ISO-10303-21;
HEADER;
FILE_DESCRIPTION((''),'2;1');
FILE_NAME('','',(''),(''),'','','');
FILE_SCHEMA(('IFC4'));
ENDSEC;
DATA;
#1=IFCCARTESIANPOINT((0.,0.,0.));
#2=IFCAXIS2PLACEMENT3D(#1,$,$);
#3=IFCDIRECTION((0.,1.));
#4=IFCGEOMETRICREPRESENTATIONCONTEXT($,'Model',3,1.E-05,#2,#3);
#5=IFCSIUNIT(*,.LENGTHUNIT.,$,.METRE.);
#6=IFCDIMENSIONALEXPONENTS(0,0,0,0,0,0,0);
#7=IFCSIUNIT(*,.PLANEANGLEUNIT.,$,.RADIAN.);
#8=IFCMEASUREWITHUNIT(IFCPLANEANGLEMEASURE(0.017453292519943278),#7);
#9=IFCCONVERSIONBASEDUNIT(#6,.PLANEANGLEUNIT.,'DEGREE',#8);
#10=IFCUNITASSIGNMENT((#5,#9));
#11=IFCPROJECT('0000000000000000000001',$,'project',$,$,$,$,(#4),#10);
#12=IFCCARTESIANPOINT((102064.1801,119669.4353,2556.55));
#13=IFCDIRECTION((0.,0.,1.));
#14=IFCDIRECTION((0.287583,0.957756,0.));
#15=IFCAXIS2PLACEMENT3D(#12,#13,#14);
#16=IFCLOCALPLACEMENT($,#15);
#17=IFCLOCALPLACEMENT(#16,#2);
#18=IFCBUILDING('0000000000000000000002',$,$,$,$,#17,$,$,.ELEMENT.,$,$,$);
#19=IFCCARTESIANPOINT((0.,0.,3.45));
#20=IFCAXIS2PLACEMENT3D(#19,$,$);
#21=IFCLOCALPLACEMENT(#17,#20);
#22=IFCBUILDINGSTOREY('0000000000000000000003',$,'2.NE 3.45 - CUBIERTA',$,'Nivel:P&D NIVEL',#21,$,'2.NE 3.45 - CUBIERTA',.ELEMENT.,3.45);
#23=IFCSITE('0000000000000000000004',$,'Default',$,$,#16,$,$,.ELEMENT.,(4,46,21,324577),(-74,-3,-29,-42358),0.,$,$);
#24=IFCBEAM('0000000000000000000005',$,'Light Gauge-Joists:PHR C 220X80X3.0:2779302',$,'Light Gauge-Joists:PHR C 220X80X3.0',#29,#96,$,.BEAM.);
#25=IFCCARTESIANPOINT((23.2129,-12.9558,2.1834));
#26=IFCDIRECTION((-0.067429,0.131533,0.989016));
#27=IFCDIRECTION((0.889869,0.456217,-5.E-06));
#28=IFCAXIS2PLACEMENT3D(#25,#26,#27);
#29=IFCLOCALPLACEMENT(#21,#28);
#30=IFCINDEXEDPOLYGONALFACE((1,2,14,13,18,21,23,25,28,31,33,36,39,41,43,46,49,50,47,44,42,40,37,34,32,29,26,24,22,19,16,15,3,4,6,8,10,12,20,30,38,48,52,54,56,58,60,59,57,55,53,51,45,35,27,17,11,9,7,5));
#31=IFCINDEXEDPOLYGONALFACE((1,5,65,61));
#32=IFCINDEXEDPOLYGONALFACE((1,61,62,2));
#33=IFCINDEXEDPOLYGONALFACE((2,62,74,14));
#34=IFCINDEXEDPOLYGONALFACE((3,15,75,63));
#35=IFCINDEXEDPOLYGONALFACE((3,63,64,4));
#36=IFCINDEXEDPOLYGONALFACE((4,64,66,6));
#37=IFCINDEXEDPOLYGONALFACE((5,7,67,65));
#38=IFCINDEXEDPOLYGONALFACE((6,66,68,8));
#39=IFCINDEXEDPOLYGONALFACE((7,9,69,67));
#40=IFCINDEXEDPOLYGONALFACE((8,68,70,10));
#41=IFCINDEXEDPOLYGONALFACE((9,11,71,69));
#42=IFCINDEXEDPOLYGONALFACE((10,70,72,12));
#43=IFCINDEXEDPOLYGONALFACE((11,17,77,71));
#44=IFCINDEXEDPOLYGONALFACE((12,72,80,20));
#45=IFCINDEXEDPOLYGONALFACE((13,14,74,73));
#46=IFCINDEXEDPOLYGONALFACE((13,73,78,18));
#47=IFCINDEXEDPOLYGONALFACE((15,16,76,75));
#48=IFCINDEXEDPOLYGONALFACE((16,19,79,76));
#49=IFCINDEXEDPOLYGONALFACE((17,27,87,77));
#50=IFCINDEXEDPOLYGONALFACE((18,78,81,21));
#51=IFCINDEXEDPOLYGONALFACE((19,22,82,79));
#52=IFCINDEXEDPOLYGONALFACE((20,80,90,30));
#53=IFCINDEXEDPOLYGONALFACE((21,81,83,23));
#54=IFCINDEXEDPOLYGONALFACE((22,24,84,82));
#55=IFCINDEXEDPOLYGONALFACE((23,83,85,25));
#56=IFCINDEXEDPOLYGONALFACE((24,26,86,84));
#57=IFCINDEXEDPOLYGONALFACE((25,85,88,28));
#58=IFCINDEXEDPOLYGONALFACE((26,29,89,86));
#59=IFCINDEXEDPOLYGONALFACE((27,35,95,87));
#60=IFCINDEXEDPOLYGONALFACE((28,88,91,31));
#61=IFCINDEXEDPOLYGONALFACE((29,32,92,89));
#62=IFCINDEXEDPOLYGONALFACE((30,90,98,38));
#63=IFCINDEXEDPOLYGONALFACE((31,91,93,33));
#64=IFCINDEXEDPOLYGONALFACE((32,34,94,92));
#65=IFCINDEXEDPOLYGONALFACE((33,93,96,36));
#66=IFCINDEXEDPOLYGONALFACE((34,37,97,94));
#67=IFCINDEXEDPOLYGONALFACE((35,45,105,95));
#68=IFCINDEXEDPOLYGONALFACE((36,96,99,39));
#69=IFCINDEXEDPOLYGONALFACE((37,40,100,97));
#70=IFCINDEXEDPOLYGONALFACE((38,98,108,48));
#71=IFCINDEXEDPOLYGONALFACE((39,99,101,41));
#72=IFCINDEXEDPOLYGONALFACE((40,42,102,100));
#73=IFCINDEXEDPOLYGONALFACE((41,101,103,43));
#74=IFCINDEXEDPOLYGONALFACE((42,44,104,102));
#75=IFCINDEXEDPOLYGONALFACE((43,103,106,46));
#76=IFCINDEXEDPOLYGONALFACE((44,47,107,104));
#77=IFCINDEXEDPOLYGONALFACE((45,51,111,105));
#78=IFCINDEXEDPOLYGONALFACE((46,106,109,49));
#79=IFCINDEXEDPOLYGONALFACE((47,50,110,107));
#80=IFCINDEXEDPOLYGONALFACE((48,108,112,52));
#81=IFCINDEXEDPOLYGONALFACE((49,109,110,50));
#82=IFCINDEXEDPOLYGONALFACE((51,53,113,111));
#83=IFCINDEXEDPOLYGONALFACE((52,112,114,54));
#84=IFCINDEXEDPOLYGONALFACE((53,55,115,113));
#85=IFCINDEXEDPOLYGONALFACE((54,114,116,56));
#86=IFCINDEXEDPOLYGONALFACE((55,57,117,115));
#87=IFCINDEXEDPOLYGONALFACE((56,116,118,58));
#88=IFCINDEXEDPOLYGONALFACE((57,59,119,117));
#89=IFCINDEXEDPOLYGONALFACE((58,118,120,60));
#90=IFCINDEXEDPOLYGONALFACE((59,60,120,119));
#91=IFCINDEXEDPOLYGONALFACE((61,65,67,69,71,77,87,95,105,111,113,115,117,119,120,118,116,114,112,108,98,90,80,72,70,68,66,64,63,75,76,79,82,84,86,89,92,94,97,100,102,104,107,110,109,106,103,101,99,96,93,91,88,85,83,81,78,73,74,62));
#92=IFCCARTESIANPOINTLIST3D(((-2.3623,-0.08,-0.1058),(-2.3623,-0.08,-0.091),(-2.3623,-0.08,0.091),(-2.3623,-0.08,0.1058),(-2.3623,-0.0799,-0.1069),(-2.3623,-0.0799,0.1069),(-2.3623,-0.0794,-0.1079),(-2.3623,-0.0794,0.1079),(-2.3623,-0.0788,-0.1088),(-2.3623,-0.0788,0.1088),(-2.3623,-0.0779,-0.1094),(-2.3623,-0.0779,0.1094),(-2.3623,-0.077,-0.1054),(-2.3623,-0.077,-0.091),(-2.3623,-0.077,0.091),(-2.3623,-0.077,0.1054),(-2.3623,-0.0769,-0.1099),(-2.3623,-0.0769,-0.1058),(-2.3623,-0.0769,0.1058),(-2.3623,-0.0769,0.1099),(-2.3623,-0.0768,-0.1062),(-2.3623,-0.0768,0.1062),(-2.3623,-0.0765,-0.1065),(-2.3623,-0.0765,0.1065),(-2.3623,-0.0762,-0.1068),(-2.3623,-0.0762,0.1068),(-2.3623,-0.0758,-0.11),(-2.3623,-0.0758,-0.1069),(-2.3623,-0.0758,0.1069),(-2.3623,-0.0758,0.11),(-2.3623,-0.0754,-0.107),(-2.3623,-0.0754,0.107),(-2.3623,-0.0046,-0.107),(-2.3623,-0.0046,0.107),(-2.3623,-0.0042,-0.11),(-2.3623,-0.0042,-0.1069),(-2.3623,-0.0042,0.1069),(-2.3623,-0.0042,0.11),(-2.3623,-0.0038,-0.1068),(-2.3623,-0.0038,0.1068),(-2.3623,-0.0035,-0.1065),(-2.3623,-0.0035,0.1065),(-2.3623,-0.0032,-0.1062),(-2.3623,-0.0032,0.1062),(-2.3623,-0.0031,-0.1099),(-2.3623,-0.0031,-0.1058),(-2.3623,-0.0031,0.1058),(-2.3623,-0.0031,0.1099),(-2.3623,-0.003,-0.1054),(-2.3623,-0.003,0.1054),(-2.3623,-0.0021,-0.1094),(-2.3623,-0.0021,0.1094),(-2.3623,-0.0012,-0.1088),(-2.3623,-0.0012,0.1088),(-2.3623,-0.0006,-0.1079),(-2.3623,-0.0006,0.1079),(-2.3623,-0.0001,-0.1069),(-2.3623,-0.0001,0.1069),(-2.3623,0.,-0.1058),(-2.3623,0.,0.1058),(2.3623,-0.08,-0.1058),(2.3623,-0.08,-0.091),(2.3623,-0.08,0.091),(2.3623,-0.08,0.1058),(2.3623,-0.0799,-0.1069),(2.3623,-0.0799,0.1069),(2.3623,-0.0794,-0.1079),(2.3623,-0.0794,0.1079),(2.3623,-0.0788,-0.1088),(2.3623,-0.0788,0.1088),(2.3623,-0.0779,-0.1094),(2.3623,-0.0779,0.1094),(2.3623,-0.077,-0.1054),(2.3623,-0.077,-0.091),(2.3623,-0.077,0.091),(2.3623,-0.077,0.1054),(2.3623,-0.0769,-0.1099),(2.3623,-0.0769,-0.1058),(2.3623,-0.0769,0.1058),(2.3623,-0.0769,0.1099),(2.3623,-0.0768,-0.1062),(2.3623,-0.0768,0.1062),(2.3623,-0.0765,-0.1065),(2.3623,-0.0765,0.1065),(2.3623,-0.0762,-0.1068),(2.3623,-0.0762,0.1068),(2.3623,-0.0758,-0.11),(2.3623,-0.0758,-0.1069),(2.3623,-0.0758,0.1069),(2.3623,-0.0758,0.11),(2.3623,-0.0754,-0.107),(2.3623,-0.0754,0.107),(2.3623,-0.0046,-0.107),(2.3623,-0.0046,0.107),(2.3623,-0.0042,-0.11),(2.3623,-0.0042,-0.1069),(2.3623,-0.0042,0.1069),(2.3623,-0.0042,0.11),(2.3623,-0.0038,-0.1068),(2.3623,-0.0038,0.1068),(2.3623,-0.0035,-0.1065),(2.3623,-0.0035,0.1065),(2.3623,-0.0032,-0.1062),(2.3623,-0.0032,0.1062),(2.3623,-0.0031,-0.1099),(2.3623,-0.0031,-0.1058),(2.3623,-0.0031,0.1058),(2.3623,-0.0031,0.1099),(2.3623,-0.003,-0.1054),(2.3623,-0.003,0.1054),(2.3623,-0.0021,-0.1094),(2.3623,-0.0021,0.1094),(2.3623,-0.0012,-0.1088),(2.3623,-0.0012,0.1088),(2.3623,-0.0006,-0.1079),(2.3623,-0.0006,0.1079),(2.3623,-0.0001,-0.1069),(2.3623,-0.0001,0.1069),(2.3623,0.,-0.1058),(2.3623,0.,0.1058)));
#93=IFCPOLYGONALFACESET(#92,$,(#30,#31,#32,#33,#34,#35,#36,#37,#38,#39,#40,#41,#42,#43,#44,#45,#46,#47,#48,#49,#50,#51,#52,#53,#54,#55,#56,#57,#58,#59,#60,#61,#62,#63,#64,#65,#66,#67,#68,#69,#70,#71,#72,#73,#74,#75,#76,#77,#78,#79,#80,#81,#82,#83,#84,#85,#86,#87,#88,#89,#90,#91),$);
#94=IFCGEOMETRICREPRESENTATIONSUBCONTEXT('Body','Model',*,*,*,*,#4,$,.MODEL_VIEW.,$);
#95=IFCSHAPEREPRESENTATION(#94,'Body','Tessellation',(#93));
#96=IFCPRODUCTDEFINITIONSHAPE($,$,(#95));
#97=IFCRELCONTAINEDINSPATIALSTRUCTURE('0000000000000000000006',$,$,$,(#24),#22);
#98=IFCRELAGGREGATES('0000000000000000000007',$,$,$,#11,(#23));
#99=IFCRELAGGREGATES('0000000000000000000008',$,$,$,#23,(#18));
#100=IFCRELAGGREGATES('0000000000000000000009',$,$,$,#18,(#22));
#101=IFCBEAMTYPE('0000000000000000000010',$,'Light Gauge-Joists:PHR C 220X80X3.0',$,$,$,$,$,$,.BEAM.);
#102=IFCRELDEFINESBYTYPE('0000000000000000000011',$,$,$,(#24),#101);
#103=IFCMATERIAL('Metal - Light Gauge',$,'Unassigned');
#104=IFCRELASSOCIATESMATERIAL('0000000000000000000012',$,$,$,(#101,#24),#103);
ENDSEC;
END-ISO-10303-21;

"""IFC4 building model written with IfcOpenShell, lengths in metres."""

from ifc_helpers import new_model, entity, si_unit, converted_unit, direction, frame, origin, place, context, subcontext, project, spatial, line, arc, indexed_curve, outline, extrude, source, transform, mapped, material, type_object, type_shapes, element, save


model = new_model("IFC4")

# Units and contexts
model_context = context("Model", 3, precision=1e-05, world=origin(), true_north=direction((0.0, 1.0)))
body_context = subcontext(model_context, "Body", "Model", "MODEL_VIEW")
ifc_project = project(units=[si_unit("LENGTHUNIT", "METRE"), converted_unit("PLANEANGLEUNIT", "DEGREE", entity("IfcPlaneAngleMeasure", 0.017453292519943278), si_unit("PLANEANGLEUNIT", "RADIAN"), dimensions=[0, 0, 0, 0, 0, 0, 0])], contexts=[model_context])

# Site, building, storey
site_placement = place(None, frame((102064.1801, 119669.4353, 2556.55), z_axis=(0.0, 0.0, 1.0), x_axis=(0.287583, 0.957756, 0.0)))
site = spatial("IfcSite", under=ifc_project, at=site_placement, Name="Default", CompositionType="ELEMENT", RefLatitude=(4, 46, 21, 324577), RefLongitude=(-74, -3, -29, -42358), RefElevation=0.0)
building_placement = place(site_placement, origin())
building = spatial("IfcBuilding", under=site, at=building_placement, CompositionType="ELEMENT")
storey_placement = place(building_placement, frame((0.0, 0.0, 3.45)))
storey = spatial("IfcBuildingStorey", under=building, at=storey_placement, Name="2.NE 3.45 - CUBIERTA", ObjectType="Nivel:P&D NIVEL", LongName="2.NE 3.45 - CUBIERTA", CompositionType="ELEMENT", Elevation=3.45)

# Beam
ifc_material_1 = material(Name="Metal - Light Gauge", Category="Unassigned")
beam_type_1 = type_object("IfcBeamType", Name="Light Gauge-Joists:PHR C 220X80X3.0", PredefinedType="BEAM", material=ifc_material_1)
shared_shape_1 = source(origin(), body_context, "Body", "SweptSolid", [
    extrude(outline(indexed_curve([(-0.1058, -0.0477), (0.1058, -0.0477), (0.1088, -0.0465), (0.11, -0.0435), (0.11, 0.0281), (0.1088, 0.0311), (0.1058, 0.0323), (0.091, 0.0323), (0.091, 0.0293), (0.1054, 0.0293), (0.1065, 0.0288), (0.107, 0.0277), (0.107, -0.0431), (0.1065, -0.0442), (0.1054, -0.0447), (-0.1054, -0.0447), (-0.1065, -0.0442), (-0.107, -0.0431), (-0.107, 0.0277), (-0.1065, 0.0288), (-0.1054, 0.0293), (-0.091, 0.0293), (-0.091, 0.0323), (-0.1058, 0.0323), (-0.1088, 0.0311), (-0.11, 0.0281), (-0.11, -0.0435), (-0.1088, -0.0465)], segments=[line(1, 2), arc(2, 3, 4), line(4, 5), arc(5, 6, 7), line(7, 8, 9, 10), arc(10, 11, 12), line(12, 13), arc(13, 14, 15), line(15, 16), arc(16, 17, 18), line(18, 19), arc(19, 20, 21), line(21, 22, 23, 24), arc(24, 25, 26), line(26, 27), arc(27, 28, 1)], self_intersect=False)), frame((-2.3623, -0.0477, 0.0), z_axis=(1.0, 0.0, 0.0), x_axis=(0.0, 0.0, 1.0)), (0.0, 0.0, 1.0), 4.7246),
])
type_shapes(beam_type_1, [shared_shape_1])
for number, where, z_axis, x_axis, name in (
    (1, (23.2129, -12.9558, 2.1834), (-0.067429, 0.131533, 0.989016), (0.889869, 0.456217, -0.000005), "Light Gauge-Joists:PHR C 220X80X3.0:2779302"),
):
    element("IfcBeam", number, at=place(storey_placement, frame(where, z_axis=z_axis, x_axis=x_axis)), inside=storey, type_object=beam_type_1, material=ifc_material_1, Name=name, ObjectType="Light Gauge-Joists:PHR C 220X80X3.0", PredefinedType="BEAM", context=body_context, shape_type="MappedRepresentation", body=[
        mapped(shared_shape_1, transform((0.0, 0.0, 0.0), scale=1.0)),
    ])

save(model, "model.ifc")
